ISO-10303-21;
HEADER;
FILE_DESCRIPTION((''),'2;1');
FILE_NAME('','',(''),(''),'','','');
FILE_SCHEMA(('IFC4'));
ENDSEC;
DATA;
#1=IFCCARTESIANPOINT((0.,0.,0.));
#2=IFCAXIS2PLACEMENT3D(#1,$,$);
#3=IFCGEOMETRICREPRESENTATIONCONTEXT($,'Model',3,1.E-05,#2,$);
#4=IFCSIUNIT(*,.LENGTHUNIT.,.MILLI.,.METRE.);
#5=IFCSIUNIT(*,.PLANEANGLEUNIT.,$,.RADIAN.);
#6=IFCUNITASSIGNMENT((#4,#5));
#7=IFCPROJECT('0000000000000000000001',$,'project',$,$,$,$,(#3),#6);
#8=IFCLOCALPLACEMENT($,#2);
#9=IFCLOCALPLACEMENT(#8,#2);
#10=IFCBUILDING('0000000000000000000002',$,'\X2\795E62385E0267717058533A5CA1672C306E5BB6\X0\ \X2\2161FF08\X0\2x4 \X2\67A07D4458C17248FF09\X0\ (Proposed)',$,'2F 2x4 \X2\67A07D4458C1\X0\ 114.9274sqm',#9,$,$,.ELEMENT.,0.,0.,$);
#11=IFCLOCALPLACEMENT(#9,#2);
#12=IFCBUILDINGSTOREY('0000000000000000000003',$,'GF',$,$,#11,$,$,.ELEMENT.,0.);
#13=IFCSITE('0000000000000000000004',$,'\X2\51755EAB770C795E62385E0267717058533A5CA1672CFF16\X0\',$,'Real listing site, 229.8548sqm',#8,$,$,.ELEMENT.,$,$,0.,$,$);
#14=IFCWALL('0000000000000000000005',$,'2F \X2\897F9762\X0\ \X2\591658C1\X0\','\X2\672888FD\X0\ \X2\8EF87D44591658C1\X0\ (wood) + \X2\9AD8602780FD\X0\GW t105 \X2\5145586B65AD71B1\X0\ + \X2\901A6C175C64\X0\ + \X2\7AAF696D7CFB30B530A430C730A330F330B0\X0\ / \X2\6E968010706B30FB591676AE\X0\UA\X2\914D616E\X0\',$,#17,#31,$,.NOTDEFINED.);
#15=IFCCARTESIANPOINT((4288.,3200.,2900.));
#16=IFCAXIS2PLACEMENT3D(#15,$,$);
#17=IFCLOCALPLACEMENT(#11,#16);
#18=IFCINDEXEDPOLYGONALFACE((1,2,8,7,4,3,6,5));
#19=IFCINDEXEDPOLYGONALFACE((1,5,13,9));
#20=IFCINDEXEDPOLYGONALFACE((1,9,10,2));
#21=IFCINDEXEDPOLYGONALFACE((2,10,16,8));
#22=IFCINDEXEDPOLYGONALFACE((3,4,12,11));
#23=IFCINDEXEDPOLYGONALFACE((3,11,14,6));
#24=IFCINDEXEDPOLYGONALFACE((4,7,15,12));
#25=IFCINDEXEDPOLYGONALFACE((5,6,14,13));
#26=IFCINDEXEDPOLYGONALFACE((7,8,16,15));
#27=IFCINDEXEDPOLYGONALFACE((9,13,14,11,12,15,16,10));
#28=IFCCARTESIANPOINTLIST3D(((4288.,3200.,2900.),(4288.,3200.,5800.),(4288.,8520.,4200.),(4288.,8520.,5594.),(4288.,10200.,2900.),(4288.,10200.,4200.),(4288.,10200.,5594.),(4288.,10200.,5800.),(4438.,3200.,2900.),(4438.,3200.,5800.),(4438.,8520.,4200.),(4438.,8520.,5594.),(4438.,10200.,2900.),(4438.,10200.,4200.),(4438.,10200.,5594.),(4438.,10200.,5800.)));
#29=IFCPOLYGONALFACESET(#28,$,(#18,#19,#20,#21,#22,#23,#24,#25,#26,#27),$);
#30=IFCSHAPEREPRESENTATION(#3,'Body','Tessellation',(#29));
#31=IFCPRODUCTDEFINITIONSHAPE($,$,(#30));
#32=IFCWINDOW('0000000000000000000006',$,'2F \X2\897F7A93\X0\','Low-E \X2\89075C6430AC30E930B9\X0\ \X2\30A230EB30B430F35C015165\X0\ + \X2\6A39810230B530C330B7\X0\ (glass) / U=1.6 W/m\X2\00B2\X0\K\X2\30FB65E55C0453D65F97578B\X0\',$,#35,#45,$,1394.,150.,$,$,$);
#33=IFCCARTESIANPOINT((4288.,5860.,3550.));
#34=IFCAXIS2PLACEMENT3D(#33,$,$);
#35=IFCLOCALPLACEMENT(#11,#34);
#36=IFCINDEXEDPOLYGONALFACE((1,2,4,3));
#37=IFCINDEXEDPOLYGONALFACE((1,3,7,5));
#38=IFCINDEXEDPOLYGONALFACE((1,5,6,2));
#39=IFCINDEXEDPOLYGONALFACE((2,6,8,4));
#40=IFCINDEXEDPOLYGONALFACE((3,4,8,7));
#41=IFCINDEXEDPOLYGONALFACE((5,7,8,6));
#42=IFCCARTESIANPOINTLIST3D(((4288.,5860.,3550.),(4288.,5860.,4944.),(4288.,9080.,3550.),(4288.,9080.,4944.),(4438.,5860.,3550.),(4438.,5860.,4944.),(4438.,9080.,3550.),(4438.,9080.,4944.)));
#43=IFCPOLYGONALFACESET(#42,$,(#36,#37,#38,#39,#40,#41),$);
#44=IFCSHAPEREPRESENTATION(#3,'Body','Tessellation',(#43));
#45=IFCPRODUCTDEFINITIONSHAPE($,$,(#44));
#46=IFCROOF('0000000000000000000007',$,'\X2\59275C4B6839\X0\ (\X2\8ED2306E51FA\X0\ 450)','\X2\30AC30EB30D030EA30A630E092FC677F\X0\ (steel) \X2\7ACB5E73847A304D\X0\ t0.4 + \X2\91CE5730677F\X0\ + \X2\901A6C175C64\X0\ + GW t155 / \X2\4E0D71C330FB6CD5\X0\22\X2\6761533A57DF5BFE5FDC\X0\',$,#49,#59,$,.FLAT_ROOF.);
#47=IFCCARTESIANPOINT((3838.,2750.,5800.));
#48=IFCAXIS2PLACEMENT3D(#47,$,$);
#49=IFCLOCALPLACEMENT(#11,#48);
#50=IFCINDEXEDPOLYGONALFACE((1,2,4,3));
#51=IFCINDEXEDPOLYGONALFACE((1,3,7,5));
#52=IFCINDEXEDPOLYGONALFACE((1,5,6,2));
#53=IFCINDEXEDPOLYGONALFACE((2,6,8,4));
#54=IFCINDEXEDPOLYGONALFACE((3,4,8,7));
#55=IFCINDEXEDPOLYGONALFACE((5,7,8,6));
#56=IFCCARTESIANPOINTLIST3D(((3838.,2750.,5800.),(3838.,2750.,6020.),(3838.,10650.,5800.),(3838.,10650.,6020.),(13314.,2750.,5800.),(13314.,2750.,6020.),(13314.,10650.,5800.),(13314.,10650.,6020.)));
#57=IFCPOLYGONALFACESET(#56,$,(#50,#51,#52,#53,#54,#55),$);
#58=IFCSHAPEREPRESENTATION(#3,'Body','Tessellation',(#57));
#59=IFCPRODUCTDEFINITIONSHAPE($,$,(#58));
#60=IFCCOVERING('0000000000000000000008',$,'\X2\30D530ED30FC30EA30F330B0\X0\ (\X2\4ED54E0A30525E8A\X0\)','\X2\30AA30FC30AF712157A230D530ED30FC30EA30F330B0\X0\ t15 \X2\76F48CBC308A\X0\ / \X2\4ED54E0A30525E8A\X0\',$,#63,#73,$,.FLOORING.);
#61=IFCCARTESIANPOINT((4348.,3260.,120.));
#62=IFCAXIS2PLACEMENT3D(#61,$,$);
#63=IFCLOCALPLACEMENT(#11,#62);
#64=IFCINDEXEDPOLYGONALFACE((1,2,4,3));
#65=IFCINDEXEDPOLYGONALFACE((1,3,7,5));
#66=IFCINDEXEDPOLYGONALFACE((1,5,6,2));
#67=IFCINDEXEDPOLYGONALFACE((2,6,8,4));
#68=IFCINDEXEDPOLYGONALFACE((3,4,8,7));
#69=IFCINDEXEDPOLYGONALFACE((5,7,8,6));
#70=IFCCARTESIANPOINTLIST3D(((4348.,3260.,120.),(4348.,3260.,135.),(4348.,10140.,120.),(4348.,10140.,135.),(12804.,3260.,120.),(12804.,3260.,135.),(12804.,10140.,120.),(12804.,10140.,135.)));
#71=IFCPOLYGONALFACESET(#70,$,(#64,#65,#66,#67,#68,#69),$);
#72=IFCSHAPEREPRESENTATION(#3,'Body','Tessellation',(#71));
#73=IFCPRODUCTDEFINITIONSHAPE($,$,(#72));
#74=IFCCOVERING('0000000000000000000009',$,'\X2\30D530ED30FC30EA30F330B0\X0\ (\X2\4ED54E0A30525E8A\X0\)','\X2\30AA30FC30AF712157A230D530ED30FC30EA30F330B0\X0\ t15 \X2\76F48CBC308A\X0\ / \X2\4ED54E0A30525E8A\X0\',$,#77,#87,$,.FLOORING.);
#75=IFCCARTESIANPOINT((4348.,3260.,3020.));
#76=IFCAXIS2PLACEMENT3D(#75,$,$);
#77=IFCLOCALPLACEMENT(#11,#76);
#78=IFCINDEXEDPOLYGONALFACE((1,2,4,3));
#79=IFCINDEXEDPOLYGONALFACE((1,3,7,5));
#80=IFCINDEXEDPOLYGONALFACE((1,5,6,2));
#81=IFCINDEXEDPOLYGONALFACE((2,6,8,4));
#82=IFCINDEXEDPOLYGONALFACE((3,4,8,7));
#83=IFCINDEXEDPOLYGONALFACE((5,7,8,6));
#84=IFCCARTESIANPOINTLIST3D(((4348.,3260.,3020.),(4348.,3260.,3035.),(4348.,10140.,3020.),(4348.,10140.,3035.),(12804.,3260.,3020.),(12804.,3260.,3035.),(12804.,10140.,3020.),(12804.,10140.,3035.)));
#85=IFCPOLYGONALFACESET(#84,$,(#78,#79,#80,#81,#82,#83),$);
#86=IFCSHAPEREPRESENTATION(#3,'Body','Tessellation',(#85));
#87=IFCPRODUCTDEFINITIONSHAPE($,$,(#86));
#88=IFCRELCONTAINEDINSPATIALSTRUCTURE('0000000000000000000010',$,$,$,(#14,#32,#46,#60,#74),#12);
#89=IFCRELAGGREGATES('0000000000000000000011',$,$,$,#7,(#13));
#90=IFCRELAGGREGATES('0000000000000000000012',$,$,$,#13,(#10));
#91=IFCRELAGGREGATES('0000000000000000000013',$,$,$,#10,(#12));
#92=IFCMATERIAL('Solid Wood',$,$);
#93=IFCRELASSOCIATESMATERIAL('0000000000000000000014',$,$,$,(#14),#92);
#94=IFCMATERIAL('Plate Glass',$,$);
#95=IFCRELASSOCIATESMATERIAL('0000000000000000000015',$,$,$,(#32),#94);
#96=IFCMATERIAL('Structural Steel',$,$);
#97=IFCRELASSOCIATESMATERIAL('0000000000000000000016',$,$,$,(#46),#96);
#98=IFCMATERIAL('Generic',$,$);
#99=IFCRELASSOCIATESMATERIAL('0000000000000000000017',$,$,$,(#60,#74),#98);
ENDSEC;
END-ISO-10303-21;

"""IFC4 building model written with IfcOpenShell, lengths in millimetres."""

from ifc_helpers import new_model, si_unit, frame, frame_2d, origin, place, context, project, spatial, rectangle, extrude, material, element, fill, save


model = new_model("IFC4")

# Units and contexts
model_context = context("Model", 3, precision=1e-05, world=origin())
ifc_project = project(units=[si_unit("LENGTHUNIT", "METRE", prefix="MILLI"), si_unit("PLANEANGLEUNIT", "RADIAN")], contexts=[model_context])

# Site, building, storey
site_placement = place(None, origin())
site = spatial("IfcSite", under=ifc_project, at=site_placement, Name="兵庫県神戸市東灘区岡本６", ObjectType="Real listing site, 229.8548sqm", CompositionType="ELEMENT", RefElevation=0.0)
building_placement = place(site_placement, origin())
building = spatial("IfcBuilding", under=site, at=building_placement, Name="神戸市東灘区岡本の家 Ⅱ（2x4 枠組壁版） (Proposed)", ObjectType="2F 2x4 枠組壁 114.9274sqm", CompositionType="ELEMENT", ElevationOfRefHeight=0.0, ElevationOfTerrain=0.0)
storey_placement = place(building_placement, origin())
storey = spatial("IfcBuildingStorey", under=building, at=storey_placement, Name="GF", CompositionType="ELEMENT", Elevation=0.0)

# Shared definitions
ifc_material_1 = material(Name="Solid Wood")

# Shared definitions
ifc_material_2 = material(Name="Plate Glass")

# Wall, opening, window
wall_1_placement = place(storey_placement, frame((4288.0, 3200.0, 2900.0)))
wall_1 = element("IfcWall", 1, at=wall_1_placement, inside=storey, material=ifc_material_1, Name="2F 西面 外壁", Description="木製 軸組外壁 (wood) + 高性能GW t105 充填断熱 + 通気層 + 窯業系サイディング / 準耐火・外皮UA配慮", PredefinedType="NOTDEFINED", context=model_context, shape_type="SweptSolid", body=[
    extrude(rectangle(XDim=150.0, YDim=7000.0, at=frame_2d((75.0, 3500.0))), frame((4288.0, 3200.0, 2900.0)), (0.0, 0.0, 1.0), 2900.0),
])
opening_1_placement = place(storey_placement, frame((4288.0, 5860.0, 3550.0)))
opening_1 = element("IfcOpeningElement", 2, at=opening_1_placement, cuts=wall_1, PredefinedType="NOTDEFINED", context=model_context, shape_type="SweptSolid", body=[
    extrude(rectangle(XDim=150.0, YDim=3220.0, at=frame_2d((75.0, 1610.0))), frame((4288.0, 5860.0, 3550.0)), (0.0, 0.0, 1.0), 1394.0),
])
window_1_placement = place(storey_placement, frame((4288.0, 5860.0, 3550.0)))
window_1 = element("IfcWindow", 3, at=window_1_placement, inside=storey, material=ifc_material_2, Name="2F 西窓", Description="Low-E 複層ガラス アルゴン封入 + 樹脂サッシ (glass) / U=1.6 W/m²K・日射取得型", OverallHeight=1394.0, OverallWidth=150.0, context=model_context, shape_type="SweptSolid", body=[
    extrude(rectangle(XDim=150.0, YDim=3220.0, at=frame_2d((75.0, 1610.0))), frame((4288.0, 5860.0, 3550.0)), (0.0, 0.0, 1.0), 1394.0),
])
fill(opening_1, window_1)

# Roof
ifc_material_3 = material(Name="Structural Steel")
roof_placement = place(storey_placement, frame((3838.0, 2750.0, 5800.0)))
element("IfcRoof", 4, at=roof_placement, inside=storey, material=ifc_material_3, Name="大屋根 (軒の出 450)", Description="ガルバリウム鋼板 (steel) 立平葺き t0.4 + 野地板 + 通気層 + GW t155 / 不燃・法22条区域対応", PredefinedType="FLAT_ROOF", context=model_context, shape_type="SweptSolid", body=[
    extrude(rectangle(XDim=9476.0, YDim=7900.0, at=frame_2d((4738.0, 3950.0))), frame((3838.0, 2750.0, 5800.0)), (0.0, 0.0, 1.0), 220.0),
])

# Coverings
ifc_material_4 = material(Name="Generic")
covering_1_placement = place(storey_placement, frame((4348.0, 3260.0, 120.0)))
element("IfcCovering", 5, at=covering_1_placement, inside=storey, material=ifc_material_4, Name="フローリング (仕上げ床)", Description="オーク無垢フローリング t15 直貼り / 仕上げ床", PredefinedType="FLOORING", context=model_context, shape_type="SweptSolid", body=[
    extrude(rectangle(XDim=8456.0, YDim=6880.0, at=frame_2d((4228.0, 3440.0))), frame((4348.0, 3260.0, 120.0)), (0.0, 0.0, 1.0), 15.0),
])
covering_2_placement = place(storey_placement, frame((4348.0, 3260.0, 3020.0)))
element("IfcCovering", 6, at=covering_2_placement, inside=storey, material=ifc_material_4, Name="フローリング (仕上げ床)", Description="オーク無垢フローリング t15 直貼り / 仕上げ床", PredefinedType="FLOORING", context=model_context, shape_type="SweptSolid", body=[
    extrude(rectangle(XDim=8456.0, YDim=6880.0, at=frame_2d((4228.0, 3440.0))), frame((4348.0, 3260.0, 3020.0)), (0.0, 0.0, 1.0), 15.0),
])

save(model, "model.ifc")
